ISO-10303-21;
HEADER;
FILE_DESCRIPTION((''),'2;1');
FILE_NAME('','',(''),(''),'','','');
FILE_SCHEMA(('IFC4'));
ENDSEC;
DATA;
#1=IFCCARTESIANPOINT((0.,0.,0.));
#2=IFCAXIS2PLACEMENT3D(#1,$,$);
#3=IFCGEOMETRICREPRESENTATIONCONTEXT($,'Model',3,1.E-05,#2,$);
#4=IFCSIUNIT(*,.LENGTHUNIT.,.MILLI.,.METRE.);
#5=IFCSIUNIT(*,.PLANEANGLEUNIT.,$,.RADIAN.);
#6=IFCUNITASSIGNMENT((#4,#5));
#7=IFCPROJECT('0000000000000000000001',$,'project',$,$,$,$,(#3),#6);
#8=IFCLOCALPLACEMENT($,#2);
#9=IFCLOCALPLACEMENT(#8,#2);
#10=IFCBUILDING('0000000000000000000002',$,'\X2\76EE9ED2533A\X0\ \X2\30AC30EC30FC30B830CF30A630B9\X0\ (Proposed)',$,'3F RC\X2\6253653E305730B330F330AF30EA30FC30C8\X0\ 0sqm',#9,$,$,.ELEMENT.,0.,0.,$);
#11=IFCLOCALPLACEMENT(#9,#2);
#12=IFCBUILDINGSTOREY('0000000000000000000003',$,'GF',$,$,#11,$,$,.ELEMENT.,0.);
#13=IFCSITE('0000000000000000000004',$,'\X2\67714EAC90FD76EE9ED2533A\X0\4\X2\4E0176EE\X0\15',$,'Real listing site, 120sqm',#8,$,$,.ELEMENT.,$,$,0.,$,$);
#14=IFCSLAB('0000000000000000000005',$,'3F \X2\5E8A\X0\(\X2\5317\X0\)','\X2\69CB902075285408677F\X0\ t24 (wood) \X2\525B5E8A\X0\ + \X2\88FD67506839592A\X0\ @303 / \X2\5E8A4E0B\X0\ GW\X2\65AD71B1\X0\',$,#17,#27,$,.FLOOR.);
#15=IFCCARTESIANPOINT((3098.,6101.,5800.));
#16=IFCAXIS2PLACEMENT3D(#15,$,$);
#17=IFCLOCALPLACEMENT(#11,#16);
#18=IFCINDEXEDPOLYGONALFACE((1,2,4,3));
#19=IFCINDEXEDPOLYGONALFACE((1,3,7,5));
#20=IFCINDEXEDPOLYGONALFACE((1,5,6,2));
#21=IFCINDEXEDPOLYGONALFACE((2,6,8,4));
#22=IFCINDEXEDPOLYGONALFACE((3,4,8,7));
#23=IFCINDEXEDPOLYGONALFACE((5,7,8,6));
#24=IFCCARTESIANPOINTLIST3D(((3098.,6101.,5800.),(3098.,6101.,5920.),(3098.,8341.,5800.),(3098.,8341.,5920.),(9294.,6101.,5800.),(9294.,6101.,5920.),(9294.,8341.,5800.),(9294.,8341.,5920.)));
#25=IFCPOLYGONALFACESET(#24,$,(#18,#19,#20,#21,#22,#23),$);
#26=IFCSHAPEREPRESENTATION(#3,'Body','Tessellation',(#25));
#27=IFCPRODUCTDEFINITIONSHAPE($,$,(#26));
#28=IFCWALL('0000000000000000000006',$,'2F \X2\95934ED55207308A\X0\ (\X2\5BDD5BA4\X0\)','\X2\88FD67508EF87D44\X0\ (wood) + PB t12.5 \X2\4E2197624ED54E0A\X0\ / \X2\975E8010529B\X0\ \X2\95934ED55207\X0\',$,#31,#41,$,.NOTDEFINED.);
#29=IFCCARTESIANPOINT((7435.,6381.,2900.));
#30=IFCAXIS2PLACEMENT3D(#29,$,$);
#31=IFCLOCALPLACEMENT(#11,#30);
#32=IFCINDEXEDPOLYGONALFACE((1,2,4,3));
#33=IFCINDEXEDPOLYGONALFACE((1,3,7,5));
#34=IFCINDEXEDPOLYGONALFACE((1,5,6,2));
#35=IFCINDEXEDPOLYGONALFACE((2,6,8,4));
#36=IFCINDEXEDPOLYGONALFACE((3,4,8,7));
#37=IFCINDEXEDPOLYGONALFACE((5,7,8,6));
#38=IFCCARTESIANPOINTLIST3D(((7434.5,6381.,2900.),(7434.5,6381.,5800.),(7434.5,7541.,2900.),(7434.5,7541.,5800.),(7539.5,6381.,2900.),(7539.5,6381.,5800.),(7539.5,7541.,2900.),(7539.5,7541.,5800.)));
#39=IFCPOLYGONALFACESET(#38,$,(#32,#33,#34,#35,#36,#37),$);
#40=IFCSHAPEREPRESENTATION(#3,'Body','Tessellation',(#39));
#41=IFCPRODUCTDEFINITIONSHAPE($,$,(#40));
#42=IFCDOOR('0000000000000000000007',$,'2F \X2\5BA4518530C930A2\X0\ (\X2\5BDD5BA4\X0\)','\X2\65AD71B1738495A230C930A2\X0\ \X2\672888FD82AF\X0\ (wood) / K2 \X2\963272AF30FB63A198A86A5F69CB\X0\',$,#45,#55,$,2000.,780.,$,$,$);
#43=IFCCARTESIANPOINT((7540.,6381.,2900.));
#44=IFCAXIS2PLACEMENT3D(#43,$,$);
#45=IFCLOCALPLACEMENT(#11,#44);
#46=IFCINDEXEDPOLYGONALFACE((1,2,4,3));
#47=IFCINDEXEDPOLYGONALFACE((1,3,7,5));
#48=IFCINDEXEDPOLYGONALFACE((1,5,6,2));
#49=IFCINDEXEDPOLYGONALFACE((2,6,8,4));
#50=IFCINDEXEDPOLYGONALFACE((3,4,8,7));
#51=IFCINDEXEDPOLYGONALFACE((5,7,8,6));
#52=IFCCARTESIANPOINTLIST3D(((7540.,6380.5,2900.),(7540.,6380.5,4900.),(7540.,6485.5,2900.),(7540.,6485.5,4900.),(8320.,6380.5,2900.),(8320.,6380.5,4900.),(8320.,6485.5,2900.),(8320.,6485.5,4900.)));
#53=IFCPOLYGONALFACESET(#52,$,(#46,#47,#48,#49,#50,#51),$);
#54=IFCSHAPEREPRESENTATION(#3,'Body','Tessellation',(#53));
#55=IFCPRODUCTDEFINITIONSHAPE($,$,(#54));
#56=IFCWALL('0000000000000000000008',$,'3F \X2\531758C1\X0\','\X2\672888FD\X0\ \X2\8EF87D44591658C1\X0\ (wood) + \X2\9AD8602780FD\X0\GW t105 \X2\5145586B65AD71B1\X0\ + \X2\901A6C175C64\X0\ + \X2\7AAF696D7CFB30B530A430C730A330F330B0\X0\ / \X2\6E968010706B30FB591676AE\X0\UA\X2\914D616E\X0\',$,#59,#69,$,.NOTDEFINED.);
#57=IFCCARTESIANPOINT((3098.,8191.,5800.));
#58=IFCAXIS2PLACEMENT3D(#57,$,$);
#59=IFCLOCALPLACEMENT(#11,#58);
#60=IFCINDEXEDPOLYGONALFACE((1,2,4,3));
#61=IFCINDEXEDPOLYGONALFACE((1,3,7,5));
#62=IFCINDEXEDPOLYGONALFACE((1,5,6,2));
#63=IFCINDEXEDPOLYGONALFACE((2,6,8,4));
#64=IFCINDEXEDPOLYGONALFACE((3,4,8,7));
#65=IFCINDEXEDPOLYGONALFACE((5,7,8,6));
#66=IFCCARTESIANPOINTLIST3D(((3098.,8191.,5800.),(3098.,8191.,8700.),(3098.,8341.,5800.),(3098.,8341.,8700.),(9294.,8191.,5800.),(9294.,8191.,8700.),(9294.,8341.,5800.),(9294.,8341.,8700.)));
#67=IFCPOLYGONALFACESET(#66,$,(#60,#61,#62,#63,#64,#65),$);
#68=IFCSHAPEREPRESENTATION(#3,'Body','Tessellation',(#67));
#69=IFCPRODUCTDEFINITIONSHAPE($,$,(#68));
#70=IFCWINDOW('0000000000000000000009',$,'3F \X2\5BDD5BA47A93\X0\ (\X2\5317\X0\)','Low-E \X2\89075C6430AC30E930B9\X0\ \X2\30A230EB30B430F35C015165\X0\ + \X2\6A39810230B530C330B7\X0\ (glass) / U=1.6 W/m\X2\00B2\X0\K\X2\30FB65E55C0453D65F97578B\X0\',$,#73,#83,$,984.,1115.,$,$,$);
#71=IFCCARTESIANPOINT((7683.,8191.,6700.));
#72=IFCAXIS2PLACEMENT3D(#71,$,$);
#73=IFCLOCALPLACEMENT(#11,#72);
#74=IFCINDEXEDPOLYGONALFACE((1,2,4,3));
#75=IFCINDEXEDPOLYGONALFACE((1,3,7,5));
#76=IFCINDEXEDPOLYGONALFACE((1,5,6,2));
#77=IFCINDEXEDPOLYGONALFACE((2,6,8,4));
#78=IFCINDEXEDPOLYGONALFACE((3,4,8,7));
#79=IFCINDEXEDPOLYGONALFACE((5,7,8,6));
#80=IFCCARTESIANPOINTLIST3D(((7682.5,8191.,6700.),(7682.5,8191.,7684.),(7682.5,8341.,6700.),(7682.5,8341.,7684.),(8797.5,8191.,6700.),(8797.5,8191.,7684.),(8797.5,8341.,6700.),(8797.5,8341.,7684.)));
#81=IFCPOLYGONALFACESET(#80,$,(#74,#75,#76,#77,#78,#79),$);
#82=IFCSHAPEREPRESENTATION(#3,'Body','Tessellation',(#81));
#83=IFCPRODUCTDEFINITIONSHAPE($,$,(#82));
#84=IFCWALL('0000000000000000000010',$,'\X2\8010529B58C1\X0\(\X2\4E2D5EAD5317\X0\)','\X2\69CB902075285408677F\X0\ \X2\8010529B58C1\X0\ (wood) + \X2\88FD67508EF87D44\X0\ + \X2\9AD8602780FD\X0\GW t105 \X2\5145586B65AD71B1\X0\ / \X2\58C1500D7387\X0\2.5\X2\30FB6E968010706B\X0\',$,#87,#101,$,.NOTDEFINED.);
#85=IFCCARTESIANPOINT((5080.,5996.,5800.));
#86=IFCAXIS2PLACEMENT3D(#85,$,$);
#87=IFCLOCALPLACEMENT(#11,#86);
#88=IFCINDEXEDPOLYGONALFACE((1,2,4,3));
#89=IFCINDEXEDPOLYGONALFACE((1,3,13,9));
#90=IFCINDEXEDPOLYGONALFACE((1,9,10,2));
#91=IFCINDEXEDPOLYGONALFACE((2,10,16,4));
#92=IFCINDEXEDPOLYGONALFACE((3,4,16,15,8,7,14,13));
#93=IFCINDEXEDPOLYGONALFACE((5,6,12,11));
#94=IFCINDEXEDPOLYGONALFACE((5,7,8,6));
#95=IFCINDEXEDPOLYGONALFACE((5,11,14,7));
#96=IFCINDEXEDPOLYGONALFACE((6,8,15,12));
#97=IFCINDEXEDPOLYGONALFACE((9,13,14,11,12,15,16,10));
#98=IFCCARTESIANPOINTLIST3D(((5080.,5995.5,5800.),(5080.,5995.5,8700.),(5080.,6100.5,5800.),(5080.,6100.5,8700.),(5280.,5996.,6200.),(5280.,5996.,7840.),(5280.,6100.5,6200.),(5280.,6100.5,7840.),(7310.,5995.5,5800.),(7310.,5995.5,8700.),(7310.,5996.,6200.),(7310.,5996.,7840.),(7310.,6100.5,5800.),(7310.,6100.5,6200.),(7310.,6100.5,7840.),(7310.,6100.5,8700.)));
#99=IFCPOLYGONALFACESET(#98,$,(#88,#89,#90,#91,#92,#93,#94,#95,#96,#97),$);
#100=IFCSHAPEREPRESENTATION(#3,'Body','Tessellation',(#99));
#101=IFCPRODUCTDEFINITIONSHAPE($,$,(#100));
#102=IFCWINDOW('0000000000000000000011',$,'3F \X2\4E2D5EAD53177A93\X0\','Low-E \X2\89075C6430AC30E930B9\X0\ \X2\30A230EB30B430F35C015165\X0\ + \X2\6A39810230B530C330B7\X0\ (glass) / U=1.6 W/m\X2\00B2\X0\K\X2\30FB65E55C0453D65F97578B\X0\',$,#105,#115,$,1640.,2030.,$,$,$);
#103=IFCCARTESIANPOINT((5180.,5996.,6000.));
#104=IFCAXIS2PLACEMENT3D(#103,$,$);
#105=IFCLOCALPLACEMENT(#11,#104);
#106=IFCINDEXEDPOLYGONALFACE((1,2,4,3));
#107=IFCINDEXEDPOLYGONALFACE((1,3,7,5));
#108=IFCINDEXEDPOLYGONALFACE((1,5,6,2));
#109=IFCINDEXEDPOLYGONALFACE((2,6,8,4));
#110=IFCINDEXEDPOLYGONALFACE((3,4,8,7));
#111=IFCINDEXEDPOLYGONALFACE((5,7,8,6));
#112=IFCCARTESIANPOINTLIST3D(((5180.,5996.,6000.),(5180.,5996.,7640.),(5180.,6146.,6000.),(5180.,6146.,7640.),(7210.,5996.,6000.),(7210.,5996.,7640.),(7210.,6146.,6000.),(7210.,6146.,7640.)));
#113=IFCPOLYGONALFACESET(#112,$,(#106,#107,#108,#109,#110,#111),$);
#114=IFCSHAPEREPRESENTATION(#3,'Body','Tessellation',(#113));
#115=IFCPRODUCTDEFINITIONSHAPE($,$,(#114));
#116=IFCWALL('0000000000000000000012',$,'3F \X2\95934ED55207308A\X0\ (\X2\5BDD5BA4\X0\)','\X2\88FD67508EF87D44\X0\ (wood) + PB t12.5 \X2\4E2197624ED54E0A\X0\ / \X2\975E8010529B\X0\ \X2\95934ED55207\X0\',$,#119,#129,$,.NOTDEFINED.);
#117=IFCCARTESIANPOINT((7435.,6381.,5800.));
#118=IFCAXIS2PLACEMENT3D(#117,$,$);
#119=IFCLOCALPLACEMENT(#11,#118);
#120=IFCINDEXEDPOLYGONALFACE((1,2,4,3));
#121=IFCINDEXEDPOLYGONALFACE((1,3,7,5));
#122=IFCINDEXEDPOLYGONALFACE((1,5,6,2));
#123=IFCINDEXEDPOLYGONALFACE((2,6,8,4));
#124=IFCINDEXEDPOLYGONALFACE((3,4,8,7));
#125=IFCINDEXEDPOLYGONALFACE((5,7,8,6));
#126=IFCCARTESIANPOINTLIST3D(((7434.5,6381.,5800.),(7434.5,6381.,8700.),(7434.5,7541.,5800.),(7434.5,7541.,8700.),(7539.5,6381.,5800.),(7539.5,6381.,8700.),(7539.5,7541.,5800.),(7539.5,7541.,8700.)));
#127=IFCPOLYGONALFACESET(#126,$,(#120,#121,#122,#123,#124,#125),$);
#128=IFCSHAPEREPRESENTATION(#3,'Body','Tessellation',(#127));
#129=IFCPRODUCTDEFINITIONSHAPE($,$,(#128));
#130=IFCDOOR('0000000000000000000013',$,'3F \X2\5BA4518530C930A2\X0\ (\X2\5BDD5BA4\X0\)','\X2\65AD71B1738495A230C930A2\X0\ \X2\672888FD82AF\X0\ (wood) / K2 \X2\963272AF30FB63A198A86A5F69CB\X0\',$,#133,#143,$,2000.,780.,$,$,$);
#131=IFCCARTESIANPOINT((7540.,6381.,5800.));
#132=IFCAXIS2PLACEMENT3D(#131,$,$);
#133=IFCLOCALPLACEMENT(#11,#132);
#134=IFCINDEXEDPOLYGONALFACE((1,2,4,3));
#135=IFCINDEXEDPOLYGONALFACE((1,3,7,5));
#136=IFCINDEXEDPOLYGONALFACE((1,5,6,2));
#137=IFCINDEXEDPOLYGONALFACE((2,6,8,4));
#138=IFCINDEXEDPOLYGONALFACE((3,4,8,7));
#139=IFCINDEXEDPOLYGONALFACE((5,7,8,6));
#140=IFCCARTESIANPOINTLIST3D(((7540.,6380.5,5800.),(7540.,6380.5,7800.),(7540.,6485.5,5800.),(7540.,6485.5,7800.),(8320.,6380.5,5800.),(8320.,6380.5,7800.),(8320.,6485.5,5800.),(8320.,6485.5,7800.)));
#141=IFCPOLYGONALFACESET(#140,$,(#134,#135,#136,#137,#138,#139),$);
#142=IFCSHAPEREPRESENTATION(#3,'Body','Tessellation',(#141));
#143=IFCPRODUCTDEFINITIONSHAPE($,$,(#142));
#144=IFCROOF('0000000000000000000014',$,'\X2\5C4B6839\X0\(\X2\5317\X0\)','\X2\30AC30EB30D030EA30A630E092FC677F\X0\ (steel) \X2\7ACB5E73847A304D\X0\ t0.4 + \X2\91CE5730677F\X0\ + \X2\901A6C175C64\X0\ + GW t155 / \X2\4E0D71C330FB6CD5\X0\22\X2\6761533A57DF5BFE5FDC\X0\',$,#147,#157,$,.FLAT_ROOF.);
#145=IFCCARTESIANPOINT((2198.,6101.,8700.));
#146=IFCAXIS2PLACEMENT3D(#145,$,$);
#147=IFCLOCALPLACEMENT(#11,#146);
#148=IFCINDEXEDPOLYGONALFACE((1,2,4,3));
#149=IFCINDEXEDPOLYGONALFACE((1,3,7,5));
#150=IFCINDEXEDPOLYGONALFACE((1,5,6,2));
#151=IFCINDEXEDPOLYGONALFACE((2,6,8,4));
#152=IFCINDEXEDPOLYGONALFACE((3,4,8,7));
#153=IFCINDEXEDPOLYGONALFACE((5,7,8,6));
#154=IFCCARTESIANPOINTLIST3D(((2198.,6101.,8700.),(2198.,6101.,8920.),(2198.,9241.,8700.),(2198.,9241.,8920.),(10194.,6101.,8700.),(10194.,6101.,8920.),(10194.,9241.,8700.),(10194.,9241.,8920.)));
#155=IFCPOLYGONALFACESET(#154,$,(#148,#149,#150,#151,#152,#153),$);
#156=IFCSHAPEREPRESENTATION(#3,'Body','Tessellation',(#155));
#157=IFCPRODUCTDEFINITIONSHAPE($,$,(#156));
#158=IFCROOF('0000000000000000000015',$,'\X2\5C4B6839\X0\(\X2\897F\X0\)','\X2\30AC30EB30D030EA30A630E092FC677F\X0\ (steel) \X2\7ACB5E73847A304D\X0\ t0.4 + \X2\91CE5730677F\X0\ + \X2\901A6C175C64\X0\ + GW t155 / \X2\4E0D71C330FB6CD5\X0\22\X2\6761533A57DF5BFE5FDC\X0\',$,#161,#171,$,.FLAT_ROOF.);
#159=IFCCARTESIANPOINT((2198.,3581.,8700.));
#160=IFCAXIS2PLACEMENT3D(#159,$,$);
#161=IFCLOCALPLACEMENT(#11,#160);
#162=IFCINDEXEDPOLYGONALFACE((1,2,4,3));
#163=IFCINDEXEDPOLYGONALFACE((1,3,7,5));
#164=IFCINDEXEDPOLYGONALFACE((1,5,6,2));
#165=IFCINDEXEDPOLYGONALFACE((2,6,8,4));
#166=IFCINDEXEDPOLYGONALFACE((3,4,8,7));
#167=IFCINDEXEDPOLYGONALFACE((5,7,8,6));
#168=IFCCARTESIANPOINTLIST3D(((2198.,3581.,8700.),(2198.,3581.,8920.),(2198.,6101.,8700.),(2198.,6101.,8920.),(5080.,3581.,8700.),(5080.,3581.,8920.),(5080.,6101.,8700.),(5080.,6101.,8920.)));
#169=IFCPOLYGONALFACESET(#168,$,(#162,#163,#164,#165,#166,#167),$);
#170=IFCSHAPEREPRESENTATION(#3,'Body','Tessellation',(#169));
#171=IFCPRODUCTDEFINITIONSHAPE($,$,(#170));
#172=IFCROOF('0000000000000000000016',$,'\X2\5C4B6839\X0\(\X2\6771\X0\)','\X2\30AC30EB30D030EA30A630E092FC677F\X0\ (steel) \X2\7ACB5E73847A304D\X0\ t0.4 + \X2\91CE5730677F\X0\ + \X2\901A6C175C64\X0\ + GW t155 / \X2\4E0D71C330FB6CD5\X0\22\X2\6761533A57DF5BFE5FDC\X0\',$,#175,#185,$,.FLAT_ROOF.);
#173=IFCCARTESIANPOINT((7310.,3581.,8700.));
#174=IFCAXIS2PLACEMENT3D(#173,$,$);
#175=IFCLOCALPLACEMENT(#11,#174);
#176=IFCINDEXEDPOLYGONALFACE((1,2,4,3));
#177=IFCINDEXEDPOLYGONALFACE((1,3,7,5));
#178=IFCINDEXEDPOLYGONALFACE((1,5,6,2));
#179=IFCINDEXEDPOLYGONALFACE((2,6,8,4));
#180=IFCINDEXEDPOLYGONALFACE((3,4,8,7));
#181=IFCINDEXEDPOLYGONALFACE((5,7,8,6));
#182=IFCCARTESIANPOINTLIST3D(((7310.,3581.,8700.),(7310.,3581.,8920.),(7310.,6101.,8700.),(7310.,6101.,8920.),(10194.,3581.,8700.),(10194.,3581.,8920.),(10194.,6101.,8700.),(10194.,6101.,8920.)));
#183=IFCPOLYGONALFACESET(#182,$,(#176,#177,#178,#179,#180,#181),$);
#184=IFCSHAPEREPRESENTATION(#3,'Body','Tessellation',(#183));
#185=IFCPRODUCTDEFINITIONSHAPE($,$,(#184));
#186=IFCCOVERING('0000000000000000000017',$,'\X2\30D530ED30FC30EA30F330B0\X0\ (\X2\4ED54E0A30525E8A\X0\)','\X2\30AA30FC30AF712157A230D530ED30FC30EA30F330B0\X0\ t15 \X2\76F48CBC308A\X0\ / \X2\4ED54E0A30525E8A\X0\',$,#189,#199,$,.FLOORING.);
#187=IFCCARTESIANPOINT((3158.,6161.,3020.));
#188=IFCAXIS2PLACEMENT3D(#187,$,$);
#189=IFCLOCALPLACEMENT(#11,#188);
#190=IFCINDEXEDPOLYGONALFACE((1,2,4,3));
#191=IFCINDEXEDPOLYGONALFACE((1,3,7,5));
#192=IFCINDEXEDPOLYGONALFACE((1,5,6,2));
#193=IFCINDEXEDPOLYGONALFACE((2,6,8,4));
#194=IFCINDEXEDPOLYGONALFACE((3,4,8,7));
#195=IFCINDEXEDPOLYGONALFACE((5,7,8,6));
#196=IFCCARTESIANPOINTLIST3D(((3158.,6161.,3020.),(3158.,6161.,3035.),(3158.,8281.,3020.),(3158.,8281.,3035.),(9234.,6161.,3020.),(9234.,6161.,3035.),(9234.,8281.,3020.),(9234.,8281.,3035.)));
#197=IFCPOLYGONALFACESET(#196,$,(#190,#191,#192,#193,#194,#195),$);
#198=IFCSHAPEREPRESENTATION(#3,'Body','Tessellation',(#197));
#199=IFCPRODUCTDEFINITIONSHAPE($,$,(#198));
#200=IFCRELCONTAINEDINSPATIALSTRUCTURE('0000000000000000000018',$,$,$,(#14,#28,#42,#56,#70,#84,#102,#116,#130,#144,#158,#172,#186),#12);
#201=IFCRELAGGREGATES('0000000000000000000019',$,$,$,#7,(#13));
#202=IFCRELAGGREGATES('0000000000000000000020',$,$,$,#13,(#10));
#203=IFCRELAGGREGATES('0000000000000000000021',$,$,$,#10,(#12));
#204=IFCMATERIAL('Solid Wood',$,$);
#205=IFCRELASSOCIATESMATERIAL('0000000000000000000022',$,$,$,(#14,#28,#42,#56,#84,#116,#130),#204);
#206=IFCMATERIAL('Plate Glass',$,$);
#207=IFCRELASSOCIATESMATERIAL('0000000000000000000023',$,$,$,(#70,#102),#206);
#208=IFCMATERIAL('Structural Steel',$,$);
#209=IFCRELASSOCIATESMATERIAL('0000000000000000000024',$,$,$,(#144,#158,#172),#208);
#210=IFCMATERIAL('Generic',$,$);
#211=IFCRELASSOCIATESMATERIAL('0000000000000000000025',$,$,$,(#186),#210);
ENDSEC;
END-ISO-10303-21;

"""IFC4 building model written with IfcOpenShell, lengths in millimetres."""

from ifc_helpers import new_model, si_unit, frame, frame_2d, origin, place, context, project, spatial, rectangle, extrude, material, element, fill, save


model = new_model("IFC4")

# Units and contexts
model_context = context("Model", 3, precision=1e-05, world=origin())
ifc_project = project(units=[si_unit("LENGTHUNIT", "METRE", prefix="MILLI"), si_unit("PLANEANGLEUNIT", "RADIAN")], contexts=[model_context])

# Site, building, storey
site_placement = place(None, origin())
site = spatial("IfcSite", under=ifc_project, at=site_placement, Name="東京都目黒区4丁目15", ObjectType="Real listing site, 120sqm", CompositionType="ELEMENT", RefElevation=0.0)
building_placement = place(site_placement, origin())
building = spatial("IfcBuilding", under=site, at=building_placement, Name="目黒区 ガレージハウス (Proposed)", ObjectType="3F RC打放しコンクリート 0sqm", CompositionType="ELEMENT", ElevationOfRefHeight=0.0, ElevationOfTerrain=0.0)
storey_placement = place(building_placement, origin())
storey = spatial("IfcBuildingStorey", under=building, at=storey_placement, Name="GF", CompositionType="ELEMENT", Elevation=0.0)

# Slab
ifc_material_1 = material(Name="Solid Wood")
slab_placement = place(storey_placement, frame((3098.0, 6101.0, 5800.0)))
element("IfcSlab", 1, at=slab_placement, inside=storey, material=ifc_material_1, Name="3F 床(北)", Description="構造用合板 t24 (wood) 剛床 + 製材根太 @303 / 床下 GW断熱", PredefinedType="FLOOR", context=model_context, shape_type="SweptSolid", body=[
    extrude(rectangle(XDim=6196.0, YDim=2240.0, at=frame_2d((3098.0, 1120.0))), frame((3098.0, 6101.0, 5800.0)), (0.0, 0.0, 1.0), 120.0),
])

# Wall
wall_1_placement = place(storey_placement, frame((7435.0, 6381.0, 2900.0)))
element("IfcWall", 2, at=wall_1_placement, inside=storey, material=ifc_material_1, Name="2F 間仕切り (寝室)", Description="製材軸組 (wood) + PB t12.5 両面仕上 / 非耐力 間仕切", PredefinedType="NOTDEFINED", context=model_context, shape_type="SweptSolid", body=[
    extrude(rectangle(XDim=105.0, YDim=1160.0, at=frame_2d((52.0, 580.0))), frame((7435.0, 6381.0, 2900.0)), (0.0, 0.0, 1.0), 2900.0),
])

# Door
door_1_placement = place(storey_placement, frame((7540.0, 6381.0, 2900.0)))
element("IfcDoor", 3, at=door_1_placement, inside=storey, material=ifc_material_1, Name="2F 室内ドア (寝室)", Description="断熱玄関ドア 木製芯 (wood) / K2 防犯・採風機構", OverallHeight=2000.0, OverallWidth=780.0, context=model_context, shape_type="SweptSolid", body=[
    extrude(rectangle(XDim=780.0, YDim=105.0, at=frame_2d((390.0, 52.0))), frame((7540.0, 6381.0, 2900.0)), (0.0, 0.0, 1.0), 2000.0),
])

# Walls, openings, windows
wall_2_placement = place(storey_placement, frame((3098.0, 8191.0, 5800.0)))
wall_2 = element("IfcWall", 4, at=wall_2_placement, inside=storey, material=ifc_material_1, Name="3F 北壁", Description="木製 軸組外壁 (wood) + 高性能GW t105 充填断熱 + 通気層 + 窯業系サイディング / 準耐火・外皮UA配慮", PredefinedType="NOTDEFINED", context=model_context, shape_type="SweptSolid", body=[
    extrude(rectangle(XDim=6196.0, YDim=150.0, at=frame_2d((3098.0, 75.0))), frame((3098.0, 8191.0, 5800.0)), (0.0, 0.0, 1.0), 2900.0),
])
opening_1_placement = place(storey_placement, frame((7683.0, 8191.0, 6700.0)))
opening_1 = element("IfcOpeningElement", 5, at=opening_1_placement, cuts=wall_2, PredefinedType="NOTDEFINED", context=model_context, shape_type="SweptSolid", body=[
    extrude(rectangle(XDim=1115.0, YDim=150.0, at=frame_2d((557.0, 75.0))), frame((7683.0, 8191.0, 6700.0)), (0.0, 0.0, 1.0), 984.0),
])
ifc_material_2 = material(Name="Plate Glass")
window_1_placement = place(storey_placement, frame((7683.0, 8191.0, 6700.0)))
window_1 = element("IfcWindow", 6, at=window_1_placement, inside=storey, material=ifc_material_2, Name="3F 寝室窓 (北)", Description="Low-E 複層ガラス アルゴン封入 + 樹脂サッシ (glass) / U=1.6 W/m²K・日射取得型", OverallHeight=984.0, OverallWidth=1115.0, context=model_context, shape_type="SweptSolid", body=[
    extrude(rectangle(XDim=1115.0, YDim=150.0, at=frame_2d((557.0, 75.0))), frame((7683.0, 8191.0, 6700.0)), (0.0, 0.0, 1.0), 984.0),
])
fill(opening_1, window_1)
wall_3_placement = place(storey_placement, frame((5080.0, 5996.0, 5800.0)))
wall_3 = element("IfcWall", 7, at=wall_3_placement, inside=storey, material=ifc_material_1, Name="耐力壁(中庭北)", Description="構造用合板 耐力壁 (wood) + 製材軸組 + 高性能GW t105 充填断熱 / 壁倍率2.5・準耐火", PredefinedType="NOTDEFINED", context=model_context, shape_type="SweptSolid", body=[
    extrude(rectangle(XDim=2230.0, YDim=105.0, at=frame_2d((1115.0, 52.0))), frame((5080.0, 5996.0, 5800.0)), (0.0, 0.0, 1.0), 2900.0),
])
opening_2_placement = place(storey_placement, frame((5180.0, 5996.0, 6000.0)))
opening_2 = element("IfcOpeningElement", 8, at=opening_2_placement, cuts=wall_3, PredefinedType="NOTDEFINED", context=model_context, shape_type="SweptSolid", body=[
    extrude(rectangle(XDim=2030.0, YDim=150.0, at=frame_2d((1015.0, 75.0))), frame((5180.0, 5996.0, 6000.0)), (0.0, 0.0, 1.0), 1640.0),
])
window_2_placement = place(storey_placement, frame((5180.0, 5996.0, 6000.0)))
window_2 = element("IfcWindow", 9, at=window_2_placement, inside=storey, material=ifc_material_2, Name="3F 中庭北窓", Description="Low-E 複層ガラス アルゴン封入 + 樹脂サッシ (glass) / U=1.6 W/m²K・日射取得型", OverallHeight=1640.0, OverallWidth=2030.0, context=model_context, shape_type="SweptSolid", body=[
    extrude(rectangle(XDim=2030.0, YDim=150.0, at=frame_2d((1015.0, 75.0))), frame((5180.0, 5996.0, 6000.0)), (0.0, 0.0, 1.0), 1640.0),
])
fill(opening_2, window_2)

# Wall
wall_4_placement = place(storey_placement, frame((7435.0, 6381.0, 5800.0)))
element("IfcWall", 10, at=wall_4_placement, inside=storey, material=ifc_material_1, Name="3F 間仕切り (寝室)", Description="製材軸組 (wood) + PB t12.5 両面仕上 / 非耐力 間仕切", PredefinedType="NOTDEFINED", context=model_context, shape_type="SweptSolid", body=[
    extrude(rectangle(XDim=105.0, YDim=1160.0, at=frame_2d((52.0, 580.0))), frame((7435.0, 6381.0, 5800.0)), (0.0, 0.0, 1.0), 2900.0),
])

# Door
door_2_placement = place(storey_placement, frame((7540.0, 6381.0, 5800.0)))
element("IfcDoor", 11, at=door_2_placement, inside=storey, material=ifc_material_1, Name="3F 室内ドア (寝室)", Description="断熱玄関ドア 木製芯 (wood) / K2 防犯・採風機構", OverallHeight=2000.0, OverallWidth=780.0, context=model_context, shape_type="SweptSolid", body=[
    extrude(rectangle(XDim=780.0, YDim=105.0, at=frame_2d((390.0, 52.0))), frame((7540.0, 6381.0, 5800.0)), (0.0, 0.0, 1.0), 2000.0),
])

# Roofs
ifc_material_3 = material(Name="Structural Steel")
for number, where, name in (
    (12, (2198.0, 6101.0, 8700.0), "屋根(北)"),
):
    element("IfcRoof", number, at=place(storey_placement, frame(where)), inside=storey, material=ifc_material_3, Name=name, Description="ガルバリウム鋼板 (steel) 立平葺き t0.4 + 野地板 + 通気層 + GW t155 / 不燃・法22条区域対応", PredefinedType="FLAT_ROOF", context=model_context, shape_type="SweptSolid", body=[
        extrude(rectangle(XDim=7996.0, YDim=3140.0, at=frame_2d((3998.0, 1570.0))), frame((2198.0, 6101.0, 8700.0)), (0.0, 0.0, 1.0), 220.0),
    ])
roof_1_placement = place(storey_placement, frame((2198.0, 3581.0, 8700.0)))
element("IfcRoof", 13, at=roof_1_placement, inside=storey, material=ifc_material_3, Name="屋根(西)", Description="ガルバリウム鋼板 (steel) 立平葺き t0.4 + 野地板 + 通気層 + GW t155 / 不燃・法22条区域対応", PredefinedType="FLAT_ROOF", context=model_context, shape_type="SweptSolid", body=[
    extrude(rectangle(XDim=2882.0, YDim=2520.0, at=frame_2d((1441.0, 1260.0))), frame((2198.0, 3581.0, 8700.0)), (0.0, 0.0, 1.0), 220.0),
])
roof_2_placement = place(storey_placement, frame((7310.0, 3581.0, 8700.0)))
element("IfcRoof", 14, at=roof_2_placement, inside=storey, material=ifc_material_3, Name="屋根(東)", Description="ガルバリウム鋼板 (steel) 立平葺き t0.4 + 野地板 + 通気層 + GW t155 / 不燃・法22条区域対応", PredefinedType="FLAT_ROOF", context=model_context, shape_type="SweptSolid", body=[
    extrude(rectangle(XDim=2884.0, YDim=2520.0, at=frame_2d((1442.0, 1260.0))), frame((7310.0, 3581.0, 8700.0)), (0.0, 0.0, 1.0), 220.0),
])

# Covering
ifc_material_4 = material(Name="Generic")
covering_1_placement = place(storey_placement, frame((3158.0, 6161.0, 3020.0)))
element("IfcCovering", 15, at=covering_1_placement, inside=storey, material=ifc_material_4, Name="フローリング (仕上げ床)", Description="オーク無垢フローリング t15 直貼り / 仕上げ床", PredefinedType="FLOORING", context=model_context, shape_type="SweptSolid", body=[
    extrude(rectangle(XDim=6076.0, YDim=2120.0, at=frame_2d((3038.0, 1060.0))), frame((3158.0, 6161.0, 3020.0)), (0.0, 0.0, 1.0), 15.0),
])

save(model, "model.ifc")
